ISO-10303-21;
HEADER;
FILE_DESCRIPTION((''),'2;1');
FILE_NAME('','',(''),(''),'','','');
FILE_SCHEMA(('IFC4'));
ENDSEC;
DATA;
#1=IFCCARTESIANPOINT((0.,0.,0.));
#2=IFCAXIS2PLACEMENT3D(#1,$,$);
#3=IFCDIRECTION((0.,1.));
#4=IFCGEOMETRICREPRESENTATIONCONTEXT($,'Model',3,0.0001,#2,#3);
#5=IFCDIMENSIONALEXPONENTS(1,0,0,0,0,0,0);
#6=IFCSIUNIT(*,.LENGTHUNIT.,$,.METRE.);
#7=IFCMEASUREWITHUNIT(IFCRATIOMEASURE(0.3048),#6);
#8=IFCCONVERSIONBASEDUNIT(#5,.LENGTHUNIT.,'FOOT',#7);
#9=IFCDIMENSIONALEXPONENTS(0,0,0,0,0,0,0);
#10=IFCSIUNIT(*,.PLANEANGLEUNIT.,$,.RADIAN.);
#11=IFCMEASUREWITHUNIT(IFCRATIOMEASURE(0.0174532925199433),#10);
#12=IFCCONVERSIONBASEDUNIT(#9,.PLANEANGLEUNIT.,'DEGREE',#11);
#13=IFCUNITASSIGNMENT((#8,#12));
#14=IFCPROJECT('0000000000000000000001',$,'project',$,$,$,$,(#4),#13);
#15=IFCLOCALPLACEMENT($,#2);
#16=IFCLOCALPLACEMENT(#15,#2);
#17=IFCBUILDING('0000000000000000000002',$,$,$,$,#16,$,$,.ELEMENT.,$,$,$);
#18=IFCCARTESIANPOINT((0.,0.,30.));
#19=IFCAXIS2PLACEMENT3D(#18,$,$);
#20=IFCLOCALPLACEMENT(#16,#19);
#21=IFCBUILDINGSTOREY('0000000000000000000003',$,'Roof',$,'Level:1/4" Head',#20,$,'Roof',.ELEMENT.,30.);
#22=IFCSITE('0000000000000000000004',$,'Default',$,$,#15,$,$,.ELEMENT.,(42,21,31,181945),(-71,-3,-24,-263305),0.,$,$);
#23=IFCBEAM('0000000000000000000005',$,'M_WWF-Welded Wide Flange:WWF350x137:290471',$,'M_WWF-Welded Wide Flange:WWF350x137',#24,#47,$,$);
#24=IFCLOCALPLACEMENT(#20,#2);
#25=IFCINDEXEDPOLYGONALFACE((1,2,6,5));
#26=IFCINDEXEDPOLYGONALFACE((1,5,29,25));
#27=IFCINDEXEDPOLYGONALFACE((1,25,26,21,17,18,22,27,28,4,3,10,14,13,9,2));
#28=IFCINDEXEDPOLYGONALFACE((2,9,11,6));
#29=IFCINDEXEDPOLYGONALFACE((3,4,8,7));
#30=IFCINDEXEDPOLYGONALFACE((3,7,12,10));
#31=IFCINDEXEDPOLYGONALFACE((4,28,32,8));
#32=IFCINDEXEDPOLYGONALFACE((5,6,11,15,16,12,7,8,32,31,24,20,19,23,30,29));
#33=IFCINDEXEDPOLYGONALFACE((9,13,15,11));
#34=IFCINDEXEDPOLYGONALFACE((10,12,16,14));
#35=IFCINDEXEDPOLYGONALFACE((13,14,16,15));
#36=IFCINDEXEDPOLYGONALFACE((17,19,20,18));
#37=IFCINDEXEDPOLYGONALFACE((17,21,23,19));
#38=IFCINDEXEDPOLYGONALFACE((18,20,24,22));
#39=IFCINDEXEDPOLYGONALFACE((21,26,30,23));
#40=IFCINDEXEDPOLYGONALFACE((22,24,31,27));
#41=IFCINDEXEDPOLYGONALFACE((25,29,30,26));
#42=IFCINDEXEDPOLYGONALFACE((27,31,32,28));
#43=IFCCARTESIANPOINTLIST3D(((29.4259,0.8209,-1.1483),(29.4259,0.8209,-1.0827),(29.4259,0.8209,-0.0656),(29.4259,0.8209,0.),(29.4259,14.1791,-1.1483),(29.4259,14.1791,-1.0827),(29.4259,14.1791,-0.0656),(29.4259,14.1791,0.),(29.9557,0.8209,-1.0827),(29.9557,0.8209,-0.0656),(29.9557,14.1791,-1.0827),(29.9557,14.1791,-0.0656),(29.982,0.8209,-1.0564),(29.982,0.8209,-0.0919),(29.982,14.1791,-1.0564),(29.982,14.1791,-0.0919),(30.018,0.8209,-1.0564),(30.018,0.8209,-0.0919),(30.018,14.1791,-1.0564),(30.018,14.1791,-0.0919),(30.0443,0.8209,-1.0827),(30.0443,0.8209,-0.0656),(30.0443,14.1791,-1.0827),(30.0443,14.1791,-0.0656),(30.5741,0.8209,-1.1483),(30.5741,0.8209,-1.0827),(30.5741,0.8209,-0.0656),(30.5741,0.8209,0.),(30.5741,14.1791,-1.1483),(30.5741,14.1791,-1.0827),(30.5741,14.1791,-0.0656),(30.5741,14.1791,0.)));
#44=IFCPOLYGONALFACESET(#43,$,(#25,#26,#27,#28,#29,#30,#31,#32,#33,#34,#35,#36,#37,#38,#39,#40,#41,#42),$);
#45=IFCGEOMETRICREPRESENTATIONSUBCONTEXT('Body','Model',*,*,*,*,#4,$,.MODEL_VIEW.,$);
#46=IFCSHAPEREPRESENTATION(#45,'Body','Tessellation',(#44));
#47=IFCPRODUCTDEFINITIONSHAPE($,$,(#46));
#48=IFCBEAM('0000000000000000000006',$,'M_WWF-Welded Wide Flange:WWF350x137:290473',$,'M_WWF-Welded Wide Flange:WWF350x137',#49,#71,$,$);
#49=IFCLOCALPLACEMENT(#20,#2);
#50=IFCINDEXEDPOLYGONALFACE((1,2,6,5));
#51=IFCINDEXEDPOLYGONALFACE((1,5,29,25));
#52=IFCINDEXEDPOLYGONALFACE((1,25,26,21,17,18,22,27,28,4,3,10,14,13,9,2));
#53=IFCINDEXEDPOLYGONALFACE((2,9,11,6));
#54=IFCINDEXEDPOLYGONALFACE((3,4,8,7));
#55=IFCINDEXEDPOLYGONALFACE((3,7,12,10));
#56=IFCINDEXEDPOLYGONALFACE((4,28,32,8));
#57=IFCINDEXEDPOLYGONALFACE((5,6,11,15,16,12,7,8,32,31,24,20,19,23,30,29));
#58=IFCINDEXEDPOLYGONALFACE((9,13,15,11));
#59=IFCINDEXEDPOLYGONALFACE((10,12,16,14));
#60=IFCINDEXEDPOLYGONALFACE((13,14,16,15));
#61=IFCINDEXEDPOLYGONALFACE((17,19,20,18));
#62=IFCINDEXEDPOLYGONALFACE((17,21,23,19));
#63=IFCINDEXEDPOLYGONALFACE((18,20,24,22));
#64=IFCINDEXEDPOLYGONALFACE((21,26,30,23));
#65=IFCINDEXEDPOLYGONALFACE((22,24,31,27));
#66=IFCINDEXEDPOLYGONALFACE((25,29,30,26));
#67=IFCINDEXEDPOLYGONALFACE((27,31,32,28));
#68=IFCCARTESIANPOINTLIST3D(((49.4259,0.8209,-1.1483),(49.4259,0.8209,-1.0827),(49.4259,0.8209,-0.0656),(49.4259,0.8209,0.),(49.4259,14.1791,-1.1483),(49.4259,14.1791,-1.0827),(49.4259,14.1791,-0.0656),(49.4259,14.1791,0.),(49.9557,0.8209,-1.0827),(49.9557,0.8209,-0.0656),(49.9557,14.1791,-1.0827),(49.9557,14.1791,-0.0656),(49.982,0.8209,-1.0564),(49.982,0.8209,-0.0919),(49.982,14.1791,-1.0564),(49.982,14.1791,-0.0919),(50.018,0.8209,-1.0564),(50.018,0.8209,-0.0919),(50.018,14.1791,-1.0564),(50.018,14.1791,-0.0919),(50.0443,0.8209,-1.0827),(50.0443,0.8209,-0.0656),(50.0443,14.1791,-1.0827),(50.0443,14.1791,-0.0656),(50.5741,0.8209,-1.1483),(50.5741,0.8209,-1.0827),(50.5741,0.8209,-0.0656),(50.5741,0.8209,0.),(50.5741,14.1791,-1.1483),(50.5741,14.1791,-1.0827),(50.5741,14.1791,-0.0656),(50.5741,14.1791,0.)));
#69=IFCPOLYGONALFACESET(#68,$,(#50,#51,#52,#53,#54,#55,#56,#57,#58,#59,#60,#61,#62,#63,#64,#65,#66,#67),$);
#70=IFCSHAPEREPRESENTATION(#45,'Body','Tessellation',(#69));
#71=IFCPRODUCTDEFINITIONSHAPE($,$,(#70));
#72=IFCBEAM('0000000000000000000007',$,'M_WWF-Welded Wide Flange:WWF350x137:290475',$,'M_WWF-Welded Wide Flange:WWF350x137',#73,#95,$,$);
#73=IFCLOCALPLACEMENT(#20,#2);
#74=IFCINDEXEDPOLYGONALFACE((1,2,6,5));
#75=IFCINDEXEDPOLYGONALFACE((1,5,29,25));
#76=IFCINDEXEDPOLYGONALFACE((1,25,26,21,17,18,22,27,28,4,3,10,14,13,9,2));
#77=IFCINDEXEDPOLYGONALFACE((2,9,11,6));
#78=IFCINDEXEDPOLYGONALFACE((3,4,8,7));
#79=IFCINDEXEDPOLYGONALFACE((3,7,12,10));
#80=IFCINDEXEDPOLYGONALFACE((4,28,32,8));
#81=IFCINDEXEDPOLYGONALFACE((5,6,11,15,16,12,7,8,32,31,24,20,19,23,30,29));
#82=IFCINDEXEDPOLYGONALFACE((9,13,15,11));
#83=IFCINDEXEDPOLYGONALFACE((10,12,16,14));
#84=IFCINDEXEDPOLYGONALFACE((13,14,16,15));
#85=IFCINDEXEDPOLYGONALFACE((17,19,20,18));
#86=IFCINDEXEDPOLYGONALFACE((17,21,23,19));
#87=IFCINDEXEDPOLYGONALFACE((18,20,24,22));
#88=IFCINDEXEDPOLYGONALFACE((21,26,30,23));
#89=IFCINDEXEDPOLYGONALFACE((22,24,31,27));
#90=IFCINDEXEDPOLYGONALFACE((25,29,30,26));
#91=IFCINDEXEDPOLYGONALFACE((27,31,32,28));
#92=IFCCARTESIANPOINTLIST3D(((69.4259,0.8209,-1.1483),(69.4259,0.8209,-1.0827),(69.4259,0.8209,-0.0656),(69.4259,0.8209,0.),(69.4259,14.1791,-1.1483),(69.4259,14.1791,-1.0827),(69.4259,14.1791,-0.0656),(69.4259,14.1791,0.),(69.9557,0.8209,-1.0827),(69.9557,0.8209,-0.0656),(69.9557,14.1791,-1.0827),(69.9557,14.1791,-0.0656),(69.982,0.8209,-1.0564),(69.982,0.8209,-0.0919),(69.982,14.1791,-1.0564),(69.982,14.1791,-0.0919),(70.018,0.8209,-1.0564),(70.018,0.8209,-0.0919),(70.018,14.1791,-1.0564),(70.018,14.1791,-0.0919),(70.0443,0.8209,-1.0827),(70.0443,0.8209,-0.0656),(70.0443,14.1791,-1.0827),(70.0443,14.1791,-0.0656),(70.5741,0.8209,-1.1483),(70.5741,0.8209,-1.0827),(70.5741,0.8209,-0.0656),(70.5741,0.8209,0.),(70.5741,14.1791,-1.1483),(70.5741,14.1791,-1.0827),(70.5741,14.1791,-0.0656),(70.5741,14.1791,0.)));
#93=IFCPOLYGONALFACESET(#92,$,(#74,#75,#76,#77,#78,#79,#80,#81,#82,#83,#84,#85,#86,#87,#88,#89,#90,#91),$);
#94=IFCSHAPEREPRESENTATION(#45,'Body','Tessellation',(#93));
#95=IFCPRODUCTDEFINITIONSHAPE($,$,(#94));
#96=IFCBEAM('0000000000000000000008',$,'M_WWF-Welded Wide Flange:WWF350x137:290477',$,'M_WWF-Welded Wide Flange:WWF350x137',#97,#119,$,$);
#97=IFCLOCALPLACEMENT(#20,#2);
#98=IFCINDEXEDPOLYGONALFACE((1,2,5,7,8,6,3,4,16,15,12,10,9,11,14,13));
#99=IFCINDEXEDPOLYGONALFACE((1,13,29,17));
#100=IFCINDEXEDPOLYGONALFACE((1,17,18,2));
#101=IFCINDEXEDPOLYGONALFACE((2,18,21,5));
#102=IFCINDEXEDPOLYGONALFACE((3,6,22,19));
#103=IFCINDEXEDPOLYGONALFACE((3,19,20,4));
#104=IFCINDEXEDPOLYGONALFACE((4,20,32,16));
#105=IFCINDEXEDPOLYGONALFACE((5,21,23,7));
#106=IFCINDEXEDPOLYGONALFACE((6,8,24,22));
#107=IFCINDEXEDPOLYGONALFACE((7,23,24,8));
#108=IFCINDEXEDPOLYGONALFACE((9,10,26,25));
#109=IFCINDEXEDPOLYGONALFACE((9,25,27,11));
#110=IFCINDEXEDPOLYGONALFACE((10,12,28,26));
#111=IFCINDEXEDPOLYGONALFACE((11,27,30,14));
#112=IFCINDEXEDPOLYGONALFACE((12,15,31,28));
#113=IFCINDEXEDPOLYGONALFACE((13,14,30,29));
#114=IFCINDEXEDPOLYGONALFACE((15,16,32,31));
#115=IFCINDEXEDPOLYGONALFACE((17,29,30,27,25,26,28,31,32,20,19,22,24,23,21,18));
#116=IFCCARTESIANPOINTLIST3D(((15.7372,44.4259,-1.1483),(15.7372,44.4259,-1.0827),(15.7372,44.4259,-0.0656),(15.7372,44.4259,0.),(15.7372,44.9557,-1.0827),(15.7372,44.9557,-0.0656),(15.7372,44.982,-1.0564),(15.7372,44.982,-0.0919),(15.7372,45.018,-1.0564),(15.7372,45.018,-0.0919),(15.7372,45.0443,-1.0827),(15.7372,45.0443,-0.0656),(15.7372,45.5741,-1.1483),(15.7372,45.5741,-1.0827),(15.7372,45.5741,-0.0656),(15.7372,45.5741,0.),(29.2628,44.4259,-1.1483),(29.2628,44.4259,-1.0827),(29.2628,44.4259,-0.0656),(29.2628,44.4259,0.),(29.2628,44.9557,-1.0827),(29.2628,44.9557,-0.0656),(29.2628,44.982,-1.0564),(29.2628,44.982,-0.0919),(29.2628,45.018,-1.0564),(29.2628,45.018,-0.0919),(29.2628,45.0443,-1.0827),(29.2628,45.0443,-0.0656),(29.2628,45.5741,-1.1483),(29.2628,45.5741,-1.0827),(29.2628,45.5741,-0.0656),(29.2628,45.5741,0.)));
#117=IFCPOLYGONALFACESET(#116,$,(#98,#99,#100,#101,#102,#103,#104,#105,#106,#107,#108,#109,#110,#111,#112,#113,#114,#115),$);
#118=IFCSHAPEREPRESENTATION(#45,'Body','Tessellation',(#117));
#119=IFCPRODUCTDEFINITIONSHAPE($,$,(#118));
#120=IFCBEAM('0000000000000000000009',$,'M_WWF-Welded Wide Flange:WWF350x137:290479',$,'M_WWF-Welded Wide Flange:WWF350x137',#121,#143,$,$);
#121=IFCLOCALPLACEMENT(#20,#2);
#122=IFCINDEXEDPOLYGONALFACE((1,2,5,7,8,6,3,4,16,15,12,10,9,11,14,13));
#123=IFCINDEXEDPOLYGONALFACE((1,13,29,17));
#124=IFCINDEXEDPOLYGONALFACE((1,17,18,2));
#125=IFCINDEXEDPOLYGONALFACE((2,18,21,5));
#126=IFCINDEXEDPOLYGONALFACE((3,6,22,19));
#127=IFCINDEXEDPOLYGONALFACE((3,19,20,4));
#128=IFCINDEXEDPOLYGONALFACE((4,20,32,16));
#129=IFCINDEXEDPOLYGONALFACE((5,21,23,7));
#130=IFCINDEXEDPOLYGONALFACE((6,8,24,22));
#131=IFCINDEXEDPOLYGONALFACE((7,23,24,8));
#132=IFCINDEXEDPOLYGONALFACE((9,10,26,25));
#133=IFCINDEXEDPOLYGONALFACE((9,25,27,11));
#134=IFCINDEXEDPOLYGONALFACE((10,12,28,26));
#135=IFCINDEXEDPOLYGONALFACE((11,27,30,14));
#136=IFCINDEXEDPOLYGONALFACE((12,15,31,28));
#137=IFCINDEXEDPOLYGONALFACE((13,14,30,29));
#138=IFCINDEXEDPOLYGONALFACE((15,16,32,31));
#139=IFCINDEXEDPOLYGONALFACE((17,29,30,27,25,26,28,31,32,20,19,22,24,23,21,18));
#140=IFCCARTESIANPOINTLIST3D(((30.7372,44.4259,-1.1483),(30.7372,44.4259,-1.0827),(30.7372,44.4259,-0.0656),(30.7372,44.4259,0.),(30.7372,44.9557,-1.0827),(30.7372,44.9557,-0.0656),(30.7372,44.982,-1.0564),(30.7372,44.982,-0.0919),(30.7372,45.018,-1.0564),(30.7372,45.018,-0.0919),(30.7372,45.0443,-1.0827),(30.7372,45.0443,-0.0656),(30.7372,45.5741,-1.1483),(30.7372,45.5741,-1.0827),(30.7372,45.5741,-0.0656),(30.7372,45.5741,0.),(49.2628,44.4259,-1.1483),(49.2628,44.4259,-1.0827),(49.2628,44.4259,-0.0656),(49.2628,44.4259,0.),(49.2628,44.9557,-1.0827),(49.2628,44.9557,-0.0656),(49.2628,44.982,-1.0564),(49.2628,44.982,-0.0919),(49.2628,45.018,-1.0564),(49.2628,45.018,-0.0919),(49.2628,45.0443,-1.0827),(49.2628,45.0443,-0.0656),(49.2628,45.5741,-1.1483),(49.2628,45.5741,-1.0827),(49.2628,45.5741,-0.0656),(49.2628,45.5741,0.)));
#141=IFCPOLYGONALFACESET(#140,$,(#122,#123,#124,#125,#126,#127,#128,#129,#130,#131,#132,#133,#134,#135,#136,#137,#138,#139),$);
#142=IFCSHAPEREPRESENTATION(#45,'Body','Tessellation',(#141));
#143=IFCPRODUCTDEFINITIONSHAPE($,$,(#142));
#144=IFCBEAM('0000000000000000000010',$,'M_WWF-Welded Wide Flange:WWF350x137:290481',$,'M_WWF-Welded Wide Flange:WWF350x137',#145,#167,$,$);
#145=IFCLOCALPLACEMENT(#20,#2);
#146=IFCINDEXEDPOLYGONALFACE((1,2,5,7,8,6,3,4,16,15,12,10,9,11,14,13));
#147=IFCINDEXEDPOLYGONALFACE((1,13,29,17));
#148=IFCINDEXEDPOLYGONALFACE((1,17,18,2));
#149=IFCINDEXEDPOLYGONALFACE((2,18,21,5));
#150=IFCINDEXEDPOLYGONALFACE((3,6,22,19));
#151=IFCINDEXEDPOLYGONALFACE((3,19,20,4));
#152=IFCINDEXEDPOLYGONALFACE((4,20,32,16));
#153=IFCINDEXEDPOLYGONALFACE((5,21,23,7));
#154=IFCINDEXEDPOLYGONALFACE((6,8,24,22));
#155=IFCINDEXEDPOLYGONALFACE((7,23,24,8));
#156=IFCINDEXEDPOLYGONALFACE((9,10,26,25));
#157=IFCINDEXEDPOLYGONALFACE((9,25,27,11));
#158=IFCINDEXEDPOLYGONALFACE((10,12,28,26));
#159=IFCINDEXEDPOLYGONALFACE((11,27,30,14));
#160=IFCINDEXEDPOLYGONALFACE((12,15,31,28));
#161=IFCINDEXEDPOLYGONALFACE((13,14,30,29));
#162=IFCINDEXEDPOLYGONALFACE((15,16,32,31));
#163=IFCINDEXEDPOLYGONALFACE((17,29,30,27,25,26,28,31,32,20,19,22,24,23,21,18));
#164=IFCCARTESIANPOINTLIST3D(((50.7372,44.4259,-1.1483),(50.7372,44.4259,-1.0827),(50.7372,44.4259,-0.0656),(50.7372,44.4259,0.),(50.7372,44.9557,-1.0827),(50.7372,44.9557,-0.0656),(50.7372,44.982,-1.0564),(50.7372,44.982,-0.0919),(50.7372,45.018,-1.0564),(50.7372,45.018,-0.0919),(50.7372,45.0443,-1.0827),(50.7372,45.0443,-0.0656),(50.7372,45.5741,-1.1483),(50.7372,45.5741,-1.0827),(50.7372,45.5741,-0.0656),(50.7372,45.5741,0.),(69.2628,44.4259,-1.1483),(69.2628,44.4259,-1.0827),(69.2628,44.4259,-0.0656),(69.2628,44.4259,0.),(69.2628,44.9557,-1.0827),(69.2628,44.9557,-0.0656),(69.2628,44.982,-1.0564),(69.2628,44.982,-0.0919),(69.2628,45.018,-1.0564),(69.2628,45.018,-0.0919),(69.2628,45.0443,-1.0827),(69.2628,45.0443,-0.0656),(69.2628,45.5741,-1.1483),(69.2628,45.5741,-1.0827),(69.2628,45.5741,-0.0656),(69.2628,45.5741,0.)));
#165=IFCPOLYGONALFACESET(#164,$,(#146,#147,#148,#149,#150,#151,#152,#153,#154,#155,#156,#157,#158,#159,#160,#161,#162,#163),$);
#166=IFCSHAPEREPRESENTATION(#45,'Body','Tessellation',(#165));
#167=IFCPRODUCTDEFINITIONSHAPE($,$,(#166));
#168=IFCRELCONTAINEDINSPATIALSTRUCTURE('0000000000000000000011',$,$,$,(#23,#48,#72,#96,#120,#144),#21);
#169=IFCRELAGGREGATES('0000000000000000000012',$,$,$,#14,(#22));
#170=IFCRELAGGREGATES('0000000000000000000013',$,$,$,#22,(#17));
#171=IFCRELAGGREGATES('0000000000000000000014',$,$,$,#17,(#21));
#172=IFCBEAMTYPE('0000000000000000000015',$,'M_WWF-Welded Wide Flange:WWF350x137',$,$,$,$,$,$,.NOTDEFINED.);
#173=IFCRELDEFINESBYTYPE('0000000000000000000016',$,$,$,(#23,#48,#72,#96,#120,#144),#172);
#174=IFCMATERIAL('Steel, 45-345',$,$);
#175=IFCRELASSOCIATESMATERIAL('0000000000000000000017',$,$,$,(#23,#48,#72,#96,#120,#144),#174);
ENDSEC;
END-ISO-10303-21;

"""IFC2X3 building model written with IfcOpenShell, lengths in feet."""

from ifc_helpers import new_model, entity, si_unit, converted_unit, direction, frame, origin, place, context, subcontext, project, spatial, polyline, outline, extrude, material, type_object, element, save


model = new_model("IFC2X3")

# Units and contexts
model_context = context("Model", 3, precision=0.0001, world=origin(), true_north=direction((0.0, 1.0)))
body_context = subcontext(model_context, "Body", "Model", "MODEL_VIEW")
ifc_project = project(units=[converted_unit("LENGTHUNIT", "FOOT", entity("IfcRatioMeasure", 0.3048), si_unit("LENGTHUNIT", "METRE"), dimensions=[1, 0, 0, 0, 0, 0, 0]), converted_unit("PLANEANGLEUNIT", "DEGREE", entity("IfcRatioMeasure", 0.0174532925199433), si_unit("PLANEANGLEUNIT", "RADIAN"), dimensions=[0, 0, 0, 0, 0, 0, 0])], contexts=[model_context])

# Site, building, storey
site_placement = place(None, origin())
site = spatial("IfcSite", under=ifc_project, at=site_placement, Name="Default", CompositionType="ELEMENT", RefLatitude=(42, 21, 31, 181945), RefLongitude=(-71, -3, -24, -263305), RefElevation=0.0)
building_placement = place(site_placement, origin())
building = spatial("IfcBuilding", under=site, at=building_placement, CompositionType="ELEMENT")
storey_placement = place(building_placement, frame((0.0, 0.0, 30.0)))
storey = spatial("IfcBuildingStorey", under=building, at=storey_placement, Name="Roof", ObjectType="Level:1/4\" Head", LongName="Roof", CompositionType="ELEMENT", Elevation=30.0)

# Beams
ifc_material = material(Name="Steel, 45-345")
beam_type = type_object("IfcBeamType", Name="M_WWF-Welded Wide Flange:WWF350x137", PredefinedType="NOTDEFINED")
beam_1_placement = place(storey_placement, frame((30.0, 0.0, 0.0), z_axis=(0.0, 0.0, 1.0), x_axis=(0.0, 1.0, 0.0)))
element("IfcBeam", 1, at=beam_1_placement, inside=storey, type_object=beam_type, material=ifc_material, Name="M_WWF-Welded Wide Flange:WWF350x137:290471", ObjectType="M_WWF-Welded Wide Flange:WWF350x137", context=body_context, shape_type="SweptSolid", body=[
    extrude(outline(polyline([(-0.5741, -0.5741), (-0.5085, -0.5741), (-0.5085, -0.0443), (-0.4823, -0.018), (0.4823, -0.018), (0.5085, -0.0443), (0.5085, -0.5741), (0.5741, -0.5741), (0.5741, 0.5741), (0.5085, 0.5741), (0.5085, 0.0443), (0.4823, 0.018), (-0.4823, 0.018), (-0.5085, 0.0443), (-0.5085, 0.5741), (-0.5741, 0.5741), (-0.5741, -0.5741)])), frame((0.8209, 0.0, -0.5741), z_axis=(1.0, 0.0, 0.0), x_axis=(0.0, 0.0, -1.0)), (0.0, 0.0, 1.0), 13.3583),
])
beam_2_placement = place(storey_placement, frame((50.0, 0.0, 0.0), z_axis=(0.0, 0.0, 1.0), x_axis=(0.0, 1.0, 0.0)))
element("IfcBeam", 2, at=beam_2_placement, inside=storey, type_object=beam_type, material=ifc_material, Name="M_WWF-Welded Wide Flange:WWF350x137:290473", ObjectType="M_WWF-Welded Wide Flange:WWF350x137", context=body_context, shape_type="SweptSolid", body=[
    extrude(outline(polyline([(-0.5741, -0.5741), (-0.5085, -0.5741), (-0.5085, -0.0443), (-0.4823, -0.018), (0.4823, -0.018), (0.5085, -0.0443), (0.5085, -0.5741), (0.5741, -0.5741), (0.5741, 0.5741), (0.5085, 0.5741), (0.5085, 0.0443), (0.4823, 0.018), (-0.4823, 0.018), (-0.5085, 0.0443), (-0.5085, 0.5741), (-0.5741, 0.5741), (-0.5741, -0.5741)])), frame((0.8209, 0.0, -0.5741), z_axis=(1.0, 0.0, 0.0), x_axis=(0.0, 0.0, -1.0)), (0.0, 0.0, 1.0), 13.3583),
])
beam_3_placement = place(storey_placement, frame((70.0, 0.0, 0.0), z_axis=(0.0, 0.0, 1.0), x_axis=(0.0, 1.0, 0.0)))
element("IfcBeam", 3, at=beam_3_placement, inside=storey, type_object=beam_type, material=ifc_material, Name="M_WWF-Welded Wide Flange:WWF350x137:290475", ObjectType="M_WWF-Welded Wide Flange:WWF350x137", context=body_context, shape_type="SweptSolid", body=[
    extrude(outline(polyline([(-0.5741, -0.5741), (-0.5085, -0.5741), (-0.5085, -0.0443), (-0.4823, -0.018), (0.4823, -0.018), (0.5085, -0.0443), (0.5085, -0.5741), (0.5741, -0.5741), (0.5741, 0.5741), (0.5085, 0.5741), (0.5085, 0.0443), (0.4823, 0.018), (-0.4823, 0.018), (-0.5085, 0.0443), (-0.5085, 0.5741), (-0.5741, 0.5741), (-0.5741, -0.5741)])), frame((0.8209, 0.0, -0.5741), z_axis=(1.0, 0.0, 0.0), x_axis=(0.0, 0.0, -1.0)), (0.0, 0.0, 1.0), 13.3583),
])
beam_4_placement = place(storey_placement, frame((15.0, 45.0, 0.0)))
element("IfcBeam", 4, at=beam_4_placement, inside=storey, type_object=beam_type, material=ifc_material, Name="M_WWF-Welded Wide Flange:WWF350x137:290477", ObjectType="M_WWF-Welded Wide Flange:WWF350x137", context=body_context, shape_type="SweptSolid", body=[
    extrude(outline(polyline([(-0.5741, -0.5741), (-0.5085, -0.5741), (-0.5085, -0.0443), (-0.4823, -0.018), (0.4823, -0.018), (0.5085, -0.0443), (0.5085, -0.5741), (0.5741, -0.5741), (0.5741, 0.5741), (0.5085, 0.5741), (0.5085, 0.0443), (0.4823, 0.018), (-0.4823, 0.018), (-0.5085, 0.0443), (-0.5085, 0.5741), (-0.5741, 0.5741), (-0.5741, -0.5741)])), frame((0.7372, 0.0, -0.5741), z_axis=(1.0, 0.0, 0.0), x_axis=(0.0, 0.0, -1.0)), (0.0, 0.0, 1.0), 13.5256),
])
beam_5_placement = place(storey_placement, frame((30.0, 45.0, 0.0)))
element("IfcBeam", 5, at=beam_5_placement, inside=storey, type_object=beam_type, material=ifc_material, Name="M_WWF-Welded Wide Flange:WWF350x137:290479", ObjectType="M_WWF-Welded Wide Flange:WWF350x137", context=body_context, shape_type="SweptSolid", body=[
    extrude(outline(polyline([(-0.5741, -0.5741), (-0.5085, -0.5741), (-0.5085, -0.0443), (-0.4823, -0.018), (0.4823, -0.018), (0.5085, -0.0443), (0.5085, -0.5741), (0.5741, -0.5741), (0.5741, 0.5741), (0.5085, 0.5741), (0.5085, 0.0443), (0.4823, 0.018), (-0.4823, 0.018), (-0.5085, 0.0443), (-0.5085, 0.5741), (-0.5741, 0.5741), (-0.5741, -0.5741)])), frame((0.7372, 0.0, -0.5741), z_axis=(1.0, 0.0, 0.0), x_axis=(0.0, 0.0, -1.0)), (0.0, 0.0, 1.0), 18.5256),
])
beam_6_placement = place(storey_placement, frame((50.0, 45.0, 0.0)))
element("IfcBeam", 6, at=beam_6_placement, inside=storey, type_object=beam_type, material=ifc_material, Name="M_WWF-Welded Wide Flange:WWF350x137:290481", ObjectType="M_WWF-Welded Wide Flange:WWF350x137", context=body_context, shape_type="SweptSolid", body=[
    extrude(outline(polyline([(-0.5741, -0.5741), (-0.5085, -0.5741), (-0.5085, -0.0443), (-0.4823, -0.018), (0.4823, -0.018), (0.5085, -0.0443), (0.5085, -0.5741), (0.5741, -0.5741), (0.5741, 0.5741), (0.5085, 0.5741), (0.5085, 0.0443), (0.4823, 0.018), (-0.4823, 0.018), (-0.5085, 0.0443), (-0.5085, 0.5741), (-0.5741, 0.5741), (-0.5741, -0.5741)])), frame((0.7372, 0.0, -0.5741), z_axis=(1.0, 0.0, 0.0), x_axis=(0.0, 0.0, -1.0)), (0.0, 0.0, 1.0), 18.5256),
])

save(model, "model.ifc")
